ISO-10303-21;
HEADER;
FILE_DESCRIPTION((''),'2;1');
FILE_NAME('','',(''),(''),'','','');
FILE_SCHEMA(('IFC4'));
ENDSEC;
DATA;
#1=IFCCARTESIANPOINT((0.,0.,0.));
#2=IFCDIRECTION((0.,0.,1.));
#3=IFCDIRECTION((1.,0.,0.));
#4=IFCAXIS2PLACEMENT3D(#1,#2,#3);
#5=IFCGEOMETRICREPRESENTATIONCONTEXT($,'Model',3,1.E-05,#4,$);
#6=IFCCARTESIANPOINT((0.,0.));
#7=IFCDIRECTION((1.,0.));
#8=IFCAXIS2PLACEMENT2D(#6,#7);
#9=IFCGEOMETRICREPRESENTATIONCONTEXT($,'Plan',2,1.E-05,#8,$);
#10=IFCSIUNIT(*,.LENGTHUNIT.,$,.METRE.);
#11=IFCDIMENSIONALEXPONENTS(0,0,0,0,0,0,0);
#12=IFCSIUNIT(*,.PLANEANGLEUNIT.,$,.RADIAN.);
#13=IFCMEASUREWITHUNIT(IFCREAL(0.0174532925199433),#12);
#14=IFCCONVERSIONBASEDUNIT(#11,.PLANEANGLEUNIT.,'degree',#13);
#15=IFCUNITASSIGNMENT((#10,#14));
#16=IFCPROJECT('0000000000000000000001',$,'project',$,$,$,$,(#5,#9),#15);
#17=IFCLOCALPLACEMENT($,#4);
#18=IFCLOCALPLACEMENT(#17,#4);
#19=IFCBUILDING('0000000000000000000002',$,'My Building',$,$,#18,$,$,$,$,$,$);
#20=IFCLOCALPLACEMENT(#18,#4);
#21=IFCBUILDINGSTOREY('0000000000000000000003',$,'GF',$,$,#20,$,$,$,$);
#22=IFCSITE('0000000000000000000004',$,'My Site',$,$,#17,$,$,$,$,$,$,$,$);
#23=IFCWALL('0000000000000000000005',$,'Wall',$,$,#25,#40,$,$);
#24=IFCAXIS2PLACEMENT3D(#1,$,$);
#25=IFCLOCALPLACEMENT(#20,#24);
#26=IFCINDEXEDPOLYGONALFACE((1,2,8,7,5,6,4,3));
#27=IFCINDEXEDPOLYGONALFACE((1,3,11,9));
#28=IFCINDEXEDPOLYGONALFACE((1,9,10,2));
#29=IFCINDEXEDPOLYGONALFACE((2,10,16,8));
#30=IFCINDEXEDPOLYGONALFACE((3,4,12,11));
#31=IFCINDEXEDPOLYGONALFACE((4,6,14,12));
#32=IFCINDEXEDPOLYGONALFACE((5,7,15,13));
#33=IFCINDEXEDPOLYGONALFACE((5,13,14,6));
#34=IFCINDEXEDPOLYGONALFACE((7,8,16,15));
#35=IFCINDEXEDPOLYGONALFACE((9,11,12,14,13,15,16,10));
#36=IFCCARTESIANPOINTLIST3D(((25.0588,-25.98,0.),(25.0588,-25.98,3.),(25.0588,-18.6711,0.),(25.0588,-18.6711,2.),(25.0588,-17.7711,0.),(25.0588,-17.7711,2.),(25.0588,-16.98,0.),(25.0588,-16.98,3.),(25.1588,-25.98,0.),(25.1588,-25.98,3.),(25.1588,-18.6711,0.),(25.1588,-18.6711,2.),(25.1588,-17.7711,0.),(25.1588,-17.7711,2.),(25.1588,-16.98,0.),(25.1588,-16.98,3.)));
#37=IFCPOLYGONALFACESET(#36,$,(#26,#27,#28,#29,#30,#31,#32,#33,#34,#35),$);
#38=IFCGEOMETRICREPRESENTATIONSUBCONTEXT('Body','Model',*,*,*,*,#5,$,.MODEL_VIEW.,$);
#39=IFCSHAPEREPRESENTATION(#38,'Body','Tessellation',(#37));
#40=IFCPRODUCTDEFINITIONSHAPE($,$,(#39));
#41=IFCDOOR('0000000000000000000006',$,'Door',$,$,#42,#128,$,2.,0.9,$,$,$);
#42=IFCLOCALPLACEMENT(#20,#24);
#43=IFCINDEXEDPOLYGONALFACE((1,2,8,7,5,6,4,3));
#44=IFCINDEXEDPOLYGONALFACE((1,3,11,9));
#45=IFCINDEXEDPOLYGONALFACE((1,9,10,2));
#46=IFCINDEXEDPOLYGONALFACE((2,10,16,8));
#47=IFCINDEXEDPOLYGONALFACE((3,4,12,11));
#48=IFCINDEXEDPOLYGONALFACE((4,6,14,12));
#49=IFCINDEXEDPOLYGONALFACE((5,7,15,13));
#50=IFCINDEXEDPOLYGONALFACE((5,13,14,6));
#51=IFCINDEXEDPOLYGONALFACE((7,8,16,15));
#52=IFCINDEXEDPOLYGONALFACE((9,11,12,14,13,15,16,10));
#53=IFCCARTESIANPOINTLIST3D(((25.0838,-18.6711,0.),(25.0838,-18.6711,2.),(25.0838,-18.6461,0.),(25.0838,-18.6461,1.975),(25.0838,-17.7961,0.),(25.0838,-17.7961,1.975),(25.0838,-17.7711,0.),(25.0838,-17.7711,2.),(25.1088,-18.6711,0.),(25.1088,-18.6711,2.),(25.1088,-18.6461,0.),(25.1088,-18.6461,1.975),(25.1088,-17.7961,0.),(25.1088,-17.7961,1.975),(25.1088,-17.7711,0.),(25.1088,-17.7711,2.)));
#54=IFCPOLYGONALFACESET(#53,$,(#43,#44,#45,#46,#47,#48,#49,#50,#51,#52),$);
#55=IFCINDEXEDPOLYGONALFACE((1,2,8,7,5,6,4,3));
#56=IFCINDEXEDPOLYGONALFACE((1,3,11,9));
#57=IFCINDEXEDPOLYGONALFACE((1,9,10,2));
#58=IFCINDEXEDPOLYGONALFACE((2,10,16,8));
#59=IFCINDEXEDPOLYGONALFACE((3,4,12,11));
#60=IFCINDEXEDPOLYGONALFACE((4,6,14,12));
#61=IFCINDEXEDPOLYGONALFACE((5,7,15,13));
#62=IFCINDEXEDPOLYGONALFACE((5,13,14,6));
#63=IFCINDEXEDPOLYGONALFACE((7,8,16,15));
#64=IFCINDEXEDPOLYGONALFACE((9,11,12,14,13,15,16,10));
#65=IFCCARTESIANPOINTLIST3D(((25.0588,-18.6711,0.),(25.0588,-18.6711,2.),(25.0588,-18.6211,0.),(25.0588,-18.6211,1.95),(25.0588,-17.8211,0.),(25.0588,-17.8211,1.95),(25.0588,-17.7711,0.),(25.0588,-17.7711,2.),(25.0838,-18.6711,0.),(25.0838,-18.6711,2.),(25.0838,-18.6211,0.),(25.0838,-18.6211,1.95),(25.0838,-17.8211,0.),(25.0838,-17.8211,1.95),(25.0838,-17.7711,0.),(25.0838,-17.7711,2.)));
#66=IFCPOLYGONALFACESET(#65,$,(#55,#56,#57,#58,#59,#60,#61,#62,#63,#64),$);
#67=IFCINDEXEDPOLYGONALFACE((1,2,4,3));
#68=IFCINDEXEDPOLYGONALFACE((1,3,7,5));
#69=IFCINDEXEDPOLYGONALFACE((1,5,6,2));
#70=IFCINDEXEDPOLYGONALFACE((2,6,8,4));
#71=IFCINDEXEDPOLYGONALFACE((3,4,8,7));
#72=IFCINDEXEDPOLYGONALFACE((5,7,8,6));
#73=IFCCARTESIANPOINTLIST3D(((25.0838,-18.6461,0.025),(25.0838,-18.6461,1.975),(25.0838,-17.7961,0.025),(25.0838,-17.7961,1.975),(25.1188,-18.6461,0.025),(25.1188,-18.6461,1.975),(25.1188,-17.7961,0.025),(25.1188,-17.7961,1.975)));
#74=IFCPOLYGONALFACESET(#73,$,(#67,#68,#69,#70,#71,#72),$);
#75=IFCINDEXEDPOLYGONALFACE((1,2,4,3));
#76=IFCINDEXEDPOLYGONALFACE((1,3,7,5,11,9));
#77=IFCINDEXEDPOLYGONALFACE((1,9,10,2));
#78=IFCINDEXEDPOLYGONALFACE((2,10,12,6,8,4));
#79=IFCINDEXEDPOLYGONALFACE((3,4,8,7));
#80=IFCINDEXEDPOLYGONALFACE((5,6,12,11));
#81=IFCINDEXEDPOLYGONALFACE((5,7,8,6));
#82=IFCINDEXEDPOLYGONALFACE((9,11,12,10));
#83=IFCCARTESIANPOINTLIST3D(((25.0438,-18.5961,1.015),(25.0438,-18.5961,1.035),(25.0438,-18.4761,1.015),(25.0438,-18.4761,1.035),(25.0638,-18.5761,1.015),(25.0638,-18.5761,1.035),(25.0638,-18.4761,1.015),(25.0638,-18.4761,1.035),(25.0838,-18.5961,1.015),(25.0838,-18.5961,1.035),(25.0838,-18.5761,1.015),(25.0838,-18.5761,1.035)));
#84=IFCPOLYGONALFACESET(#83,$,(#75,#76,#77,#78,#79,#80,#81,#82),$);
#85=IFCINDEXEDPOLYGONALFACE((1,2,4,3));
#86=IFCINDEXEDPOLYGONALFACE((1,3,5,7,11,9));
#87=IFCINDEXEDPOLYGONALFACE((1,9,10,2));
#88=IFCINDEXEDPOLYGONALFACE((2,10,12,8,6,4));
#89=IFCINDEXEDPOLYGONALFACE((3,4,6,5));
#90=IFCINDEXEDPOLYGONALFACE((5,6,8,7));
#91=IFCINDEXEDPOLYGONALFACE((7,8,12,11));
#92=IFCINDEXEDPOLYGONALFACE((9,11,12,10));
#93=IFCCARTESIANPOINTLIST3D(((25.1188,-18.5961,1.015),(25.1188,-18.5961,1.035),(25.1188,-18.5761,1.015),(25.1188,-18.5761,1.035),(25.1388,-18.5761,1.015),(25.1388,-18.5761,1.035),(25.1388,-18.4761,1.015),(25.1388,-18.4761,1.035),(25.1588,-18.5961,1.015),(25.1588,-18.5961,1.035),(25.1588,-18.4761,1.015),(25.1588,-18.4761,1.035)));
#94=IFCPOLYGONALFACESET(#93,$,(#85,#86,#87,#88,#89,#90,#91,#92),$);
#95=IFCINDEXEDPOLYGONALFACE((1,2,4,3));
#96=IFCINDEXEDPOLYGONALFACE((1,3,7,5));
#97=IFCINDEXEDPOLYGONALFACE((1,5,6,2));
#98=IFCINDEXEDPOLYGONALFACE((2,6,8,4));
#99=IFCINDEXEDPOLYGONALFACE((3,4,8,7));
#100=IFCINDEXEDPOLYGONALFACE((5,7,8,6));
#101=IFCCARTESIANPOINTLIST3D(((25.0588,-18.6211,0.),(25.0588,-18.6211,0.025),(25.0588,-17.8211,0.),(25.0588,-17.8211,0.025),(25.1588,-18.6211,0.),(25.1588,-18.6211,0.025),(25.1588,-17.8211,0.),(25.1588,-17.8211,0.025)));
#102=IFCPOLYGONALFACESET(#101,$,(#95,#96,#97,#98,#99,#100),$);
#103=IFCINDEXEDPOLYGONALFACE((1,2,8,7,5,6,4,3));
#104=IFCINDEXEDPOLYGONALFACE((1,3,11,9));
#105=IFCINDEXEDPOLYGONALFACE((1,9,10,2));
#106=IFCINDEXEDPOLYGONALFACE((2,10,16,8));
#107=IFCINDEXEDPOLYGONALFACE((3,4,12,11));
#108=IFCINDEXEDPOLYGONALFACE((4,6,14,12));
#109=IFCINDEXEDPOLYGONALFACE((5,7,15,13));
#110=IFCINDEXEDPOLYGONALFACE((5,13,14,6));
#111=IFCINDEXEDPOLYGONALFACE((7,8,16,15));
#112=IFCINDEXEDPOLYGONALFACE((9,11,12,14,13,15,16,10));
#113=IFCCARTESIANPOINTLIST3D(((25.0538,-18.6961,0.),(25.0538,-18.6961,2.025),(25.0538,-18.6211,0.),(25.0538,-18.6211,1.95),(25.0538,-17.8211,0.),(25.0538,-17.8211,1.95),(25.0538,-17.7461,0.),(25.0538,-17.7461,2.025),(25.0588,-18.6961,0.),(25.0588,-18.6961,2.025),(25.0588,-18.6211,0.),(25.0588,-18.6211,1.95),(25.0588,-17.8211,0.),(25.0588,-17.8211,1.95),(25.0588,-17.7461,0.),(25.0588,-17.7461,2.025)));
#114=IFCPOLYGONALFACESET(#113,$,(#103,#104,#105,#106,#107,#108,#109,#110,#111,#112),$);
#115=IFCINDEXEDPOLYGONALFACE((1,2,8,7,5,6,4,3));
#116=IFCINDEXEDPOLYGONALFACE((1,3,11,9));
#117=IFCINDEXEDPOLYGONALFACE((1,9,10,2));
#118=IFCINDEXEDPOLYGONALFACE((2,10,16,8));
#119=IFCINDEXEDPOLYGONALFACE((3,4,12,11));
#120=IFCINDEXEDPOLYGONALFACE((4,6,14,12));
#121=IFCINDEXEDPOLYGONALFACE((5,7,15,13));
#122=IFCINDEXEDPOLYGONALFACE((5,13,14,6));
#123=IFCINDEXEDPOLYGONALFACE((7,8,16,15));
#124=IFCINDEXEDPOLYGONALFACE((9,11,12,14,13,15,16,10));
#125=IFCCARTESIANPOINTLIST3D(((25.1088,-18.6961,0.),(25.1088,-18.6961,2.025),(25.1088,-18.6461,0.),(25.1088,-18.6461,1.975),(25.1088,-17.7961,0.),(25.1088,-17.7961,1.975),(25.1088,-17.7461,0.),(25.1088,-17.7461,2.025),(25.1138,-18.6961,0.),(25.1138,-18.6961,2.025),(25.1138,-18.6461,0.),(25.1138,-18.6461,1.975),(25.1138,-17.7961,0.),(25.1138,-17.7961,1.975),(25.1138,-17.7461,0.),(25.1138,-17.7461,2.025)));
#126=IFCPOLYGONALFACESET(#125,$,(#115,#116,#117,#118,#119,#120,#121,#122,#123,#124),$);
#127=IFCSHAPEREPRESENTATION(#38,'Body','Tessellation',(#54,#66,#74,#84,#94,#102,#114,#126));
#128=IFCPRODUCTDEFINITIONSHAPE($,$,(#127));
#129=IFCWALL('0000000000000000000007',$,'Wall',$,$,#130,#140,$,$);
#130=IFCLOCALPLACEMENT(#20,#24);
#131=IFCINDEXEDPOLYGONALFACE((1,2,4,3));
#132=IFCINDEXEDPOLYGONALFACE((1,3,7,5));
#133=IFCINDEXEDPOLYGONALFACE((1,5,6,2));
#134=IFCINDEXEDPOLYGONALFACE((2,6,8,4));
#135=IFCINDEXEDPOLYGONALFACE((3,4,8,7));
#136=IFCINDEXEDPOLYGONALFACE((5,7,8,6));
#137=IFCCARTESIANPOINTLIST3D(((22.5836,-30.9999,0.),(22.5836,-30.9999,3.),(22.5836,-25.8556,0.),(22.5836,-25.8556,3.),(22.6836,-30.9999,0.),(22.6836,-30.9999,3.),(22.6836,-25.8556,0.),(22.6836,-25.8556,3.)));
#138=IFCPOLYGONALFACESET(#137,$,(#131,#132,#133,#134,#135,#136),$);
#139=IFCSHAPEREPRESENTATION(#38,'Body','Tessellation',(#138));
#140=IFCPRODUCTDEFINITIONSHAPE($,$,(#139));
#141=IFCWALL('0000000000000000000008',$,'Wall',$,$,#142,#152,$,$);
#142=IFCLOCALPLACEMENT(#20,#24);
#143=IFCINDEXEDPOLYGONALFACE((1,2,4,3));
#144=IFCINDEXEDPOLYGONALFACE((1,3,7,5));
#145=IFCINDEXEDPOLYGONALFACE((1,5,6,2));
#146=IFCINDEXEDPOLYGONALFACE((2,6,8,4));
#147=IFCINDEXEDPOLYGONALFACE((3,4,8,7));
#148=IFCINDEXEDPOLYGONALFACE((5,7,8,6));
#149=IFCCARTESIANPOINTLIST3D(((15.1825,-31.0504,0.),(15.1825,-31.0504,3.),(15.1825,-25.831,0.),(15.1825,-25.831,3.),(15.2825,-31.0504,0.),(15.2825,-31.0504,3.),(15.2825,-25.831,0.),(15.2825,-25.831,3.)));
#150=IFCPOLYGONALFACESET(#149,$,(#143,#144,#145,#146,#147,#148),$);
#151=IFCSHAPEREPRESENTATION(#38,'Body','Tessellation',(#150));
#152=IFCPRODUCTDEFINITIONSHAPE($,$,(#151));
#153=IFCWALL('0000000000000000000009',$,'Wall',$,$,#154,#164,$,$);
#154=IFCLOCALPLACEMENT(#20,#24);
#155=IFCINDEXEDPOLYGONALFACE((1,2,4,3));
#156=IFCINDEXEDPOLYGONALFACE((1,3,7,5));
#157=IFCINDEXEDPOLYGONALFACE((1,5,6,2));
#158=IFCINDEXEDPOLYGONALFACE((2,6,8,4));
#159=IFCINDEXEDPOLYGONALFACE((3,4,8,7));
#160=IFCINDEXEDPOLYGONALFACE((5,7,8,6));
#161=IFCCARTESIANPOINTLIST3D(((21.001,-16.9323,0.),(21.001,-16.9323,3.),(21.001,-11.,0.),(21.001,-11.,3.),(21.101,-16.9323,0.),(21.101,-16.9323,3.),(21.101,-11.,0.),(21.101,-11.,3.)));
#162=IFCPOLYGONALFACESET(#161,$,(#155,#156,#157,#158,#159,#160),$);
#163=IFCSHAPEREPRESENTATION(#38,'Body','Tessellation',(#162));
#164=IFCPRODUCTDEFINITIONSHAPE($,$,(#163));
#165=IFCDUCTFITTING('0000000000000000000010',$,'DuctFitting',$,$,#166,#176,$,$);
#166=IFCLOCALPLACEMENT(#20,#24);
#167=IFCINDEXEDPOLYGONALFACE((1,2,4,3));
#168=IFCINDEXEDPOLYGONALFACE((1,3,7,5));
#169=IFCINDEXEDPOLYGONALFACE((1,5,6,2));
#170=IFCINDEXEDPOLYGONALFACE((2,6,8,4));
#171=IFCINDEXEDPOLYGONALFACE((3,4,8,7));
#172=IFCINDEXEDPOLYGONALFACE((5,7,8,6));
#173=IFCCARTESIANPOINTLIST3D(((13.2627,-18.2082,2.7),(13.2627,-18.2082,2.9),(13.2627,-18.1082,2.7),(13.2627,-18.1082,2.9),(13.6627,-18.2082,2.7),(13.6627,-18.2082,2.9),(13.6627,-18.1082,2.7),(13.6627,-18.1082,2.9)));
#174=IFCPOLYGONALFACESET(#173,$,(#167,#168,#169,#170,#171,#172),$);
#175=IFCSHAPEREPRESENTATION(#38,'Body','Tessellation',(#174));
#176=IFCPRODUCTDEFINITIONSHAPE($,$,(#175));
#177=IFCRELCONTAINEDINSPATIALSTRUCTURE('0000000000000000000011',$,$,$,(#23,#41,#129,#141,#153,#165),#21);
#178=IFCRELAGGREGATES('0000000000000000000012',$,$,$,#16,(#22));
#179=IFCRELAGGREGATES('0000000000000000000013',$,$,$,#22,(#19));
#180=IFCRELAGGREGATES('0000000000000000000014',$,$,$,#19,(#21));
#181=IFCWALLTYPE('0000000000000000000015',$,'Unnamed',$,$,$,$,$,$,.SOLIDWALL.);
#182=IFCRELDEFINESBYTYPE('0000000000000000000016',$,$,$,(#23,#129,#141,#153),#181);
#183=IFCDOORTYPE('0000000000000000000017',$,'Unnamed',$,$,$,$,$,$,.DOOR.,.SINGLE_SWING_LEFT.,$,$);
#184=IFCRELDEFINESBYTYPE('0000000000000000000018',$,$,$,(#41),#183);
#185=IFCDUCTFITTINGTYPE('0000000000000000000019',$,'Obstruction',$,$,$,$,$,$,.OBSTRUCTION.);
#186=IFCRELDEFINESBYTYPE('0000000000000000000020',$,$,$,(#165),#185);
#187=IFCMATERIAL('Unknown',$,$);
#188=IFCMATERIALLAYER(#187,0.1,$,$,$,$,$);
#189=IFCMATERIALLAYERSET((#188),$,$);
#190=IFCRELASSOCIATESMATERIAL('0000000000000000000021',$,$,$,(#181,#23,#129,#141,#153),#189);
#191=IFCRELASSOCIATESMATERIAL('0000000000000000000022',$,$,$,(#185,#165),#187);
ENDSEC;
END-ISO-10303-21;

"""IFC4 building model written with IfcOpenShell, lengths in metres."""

from ifc_helpers import new_model, entity, si_unit, converted_unit, frame, origin_with_axes, origin_2d_with_axis, place, context, subcontext, project, spatial, line, indexed_curve, rectangle, outline, extrude, shape, source, transform, mapped, material, layer, layer_set, layer_usage, material_profile, profile_set, profile_usage, type_object, type_shapes, element, fill, save


model = new_model("IFC4")

# Units and contexts
model_context = context("Model", 3, precision=1e-05, world=origin_with_axes())
plan_context = context("Plan", 2, precision=1e-05, world=origin_2d_with_axis())
body_context_1 = subcontext(model_context, "Body", "Model", "MODEL_VIEW")
body_context_2 = subcontext(plan_context, "Body", "Plan", "PLAN_VIEW")
ifc_project = project(units=[si_unit("LENGTHUNIT", "METRE"), converted_unit("PLANEANGLEUNIT", "degree", entity("IfcReal", 0.0174532925199433), si_unit("PLANEANGLEUNIT", "RADIAN"), dimensions=[0, 0, 0, 0, 0, 0, 0])], contexts=[model_context, plan_context])

# Site, building, storey
site_placement = place(None, origin_with_axes())
site = spatial("IfcSite", under=ifc_project, at=site_placement, Name="My Site")
building_placement = place(site_placement, origin_with_axes())
building = spatial("IfcBuilding", under=site, at=building_placement, Name="My Building")
storey_placement = place(building_placement, origin_with_axes())
storey = spatial("IfcBuildingStorey", under=building, at=storey_placement, Name="GF")

# Shared definitions
ifc_material = material(Name="Unknown")
ifc_layer = layer(ifc_material, 0.1)
ifc_layer_set = layer_set([ifc_layer])
wall_type = type_object("IfcWallType", Name="Unnamed", PredefinedType="SOLIDWALL", material=ifc_layer_set)

# Shared definitions
shared_shape_1 = source(origin_with_axes(), body_context_1, "Body", "SweptSolid", [
    extrude(outline(indexed_curve([(0.0, 0.0), (0.9, 0.0), (0.9, 2.0), (0.0, 2.0)], segments=[line(1, 2, 3, 4, 1)])), frame((0.0, -0.6, 0.0), z_axis=(0.0, -1.0, 0.0), x_axis=(1.0, 0.0, 0.0)), (0.0, 0.0, -1.0), 1.2),
])
door_type = type_object("IfcDoorType", Name="Unnamed", OperationType="SINGLE_SWING_LEFT", PredefinedType="DOOR")
shared_shape_2 = source(origin_with_axes(), body_context_1, "Body", "SweptSolid", [
    extrude(outline(indexed_curve([(0.0, 0.0), (0.0, 2.0), (0.9, 2.0), (0.9, 0.0), (0.875, 0.0), (0.875, 1.975), (0.025, 1.975), (0.025, 0.0)], segments=[line(1, 2, 3, 4, 5, 6, 7, 8, 1)])), frame((0.0, 0.025, 0.0), z_axis=(0.0, -1.0, 0.0), x_axis=(1.0, 0.0, 0.0)), (0.0, 0.0, -1.0), 0.025),
    extrude(outline(indexed_curve([(0.0, 0.0), (0.0, 2.0), (0.9, 2.0), (0.9, 0.0), (0.85, 0.0), (0.85, 1.95), (0.05, 1.95), (0.05, 0.0)], segments=[line(1, 2, 3, 4, 5, 6, 7, 8, 1)])), frame((0.0, 0.0, 0.0), z_axis=(0.0, -1.0, 0.0), x_axis=(1.0, 0.0, 0.0)), (0.0, 0.0, -1.0), 0.025),
    extrude(outline(indexed_curve([(0.0, 0.0), (0.85, 0.0), (0.85, 0.035), (0.0, 0.035)], segments=[line(1, 2, 3, 4, 1)])), frame((0.025, 0.025, 0.025), z_axis=(0.0, 0.0, 1.0), x_axis=(1.0, 0.0, 0.0)), (0.0, 0.0, 1.0), 1.95),
    extrude(outline(indexed_curve([(0.0, 0.0), (0.0, -0.04), (-0.12, -0.04), (-0.12, -0.02), (-0.02, -0.02), (-0.02, 0.0)], segments=[line(1, 2, 3, 4, 5, 6, 1)])), frame((0.825, 0.025, 1.015), z_axis=(0.0, 0.0, 1.0), x_axis=(1.0, 0.0, 0.0)), (0.0, 0.0, 1.0), 0.02),
    extrude(outline(indexed_curve([(0.0, 0.0), (0.0, 0.04), (-0.12, 0.04), (-0.12, 0.02), (-0.02, 0.02), (-0.02, 0.0)], segments=[line(1, 2, 3, 4, 5, 6, 1)])), frame((0.825, 0.06, 1.015), z_axis=(0.0, 0.0, 1.0), x_axis=(1.0, 0.0, 0.0)), (0.0, 0.0, 1.0), 0.02),
    extrude(outline(indexed_curve([(0.0, 0.0), (0.8, 0.0), (0.8, 0.1), (0.0, 0.1)], segments=[line(1, 2, 3, 4, 1)])), frame((0.05, 0.0, 0.0), z_axis=(0.0, 0.0, 1.0), x_axis=(1.0, 0.0, 0.0)), (0.0, 0.0, 1.0), 0.025),
    extrude(outline(indexed_curve([(0.0, 0.0), (0.0, 2.025), (0.95, 2.025), (0.95, 0.0), (0.875, 0.0), (0.875, 1.95), (0.075, 1.95), (0.075, 0.0)], segments=[line(1, 2, 3, 4, 5, 6, 7, 8, 1)])), frame((-0.025, -0.005, 0.0), z_axis=(0.0, -1.0, 0.0), x_axis=(1.0, 0.0, 0.0)), (0.0, 0.0, -1.0), 0.005),
    extrude(outline(indexed_curve([(0.0, 0.0), (0.0, 2.025), (0.95, 2.025), (0.95, 0.0), (0.9, 0.0), (0.9, 1.975), (0.05, 1.975), (0.05, 0.0)], segments=[line(1, 2, 3, 4, 5, 6, 7, 8, 1)])), frame((-0.025, 0.05, 0.0), z_axis=(0.0, -1.0, 0.0), x_axis=(1.0, 0.0, 0.0)), (0.0, 0.0, -1.0), 0.005),
])
shared_shape_3 = source(origin_with_axes(), body_context_2, "Body", "Curve2D", [
    entity("IfcIndexedPolyCurve", entity("IfcCartesianPointList2D", [[0.0, 0.0], [0.0, 0.05], [0.025, 0.05], [0.025, 0.025], [0.05, 0.025], [0.05, 0.0]]), [entity("IfcLineIndex", [1, 2, 3, 4, 5, 6, 1])]),
    entity("IfcIndexedPolyCurve", entity("IfcCartesianPointList2D", [[0.9, 0.0], [0.9, 0.05], [0.875, 0.05], [0.875, 0.025], [0.85, 0.025], [0.85, 0.0]]), [entity("IfcLineIndex", [1, 2, 3, 4, 5, 6, 1])]),
    entity("IfcTrimmedCurve", entity("IfcEllipse", entity("IfcAxis2Placement2D", entity("IfcCartesianPoint", [0.06, 0.05]), entity("IfcDirection", [1.0, 0.0])), 0.815, 0.85), [entity("IfcCartesianPoint", [0.875, 0.05])], [entity("IfcCartesianPoint", [0.06, 0.9])], True, "CARTESIAN"),
    entity("IfcIndexedPolyCurve", entity("IfcCartesianPointList2D", [[0.025, 0.05], [0.06, 0.05], [0.06, 0.9], [0.025, 0.9]]), [entity("IfcLineIndex", [1, 2, 3, 4, 1])]),
])
type_shapes(door_type, [shared_shape_2, shared_shape_3])

# Wall, opening, door
ifc_layer_usage_1 = layer_usage(ifc_layer_set, "AXIS2", "POSITIVE", 0.0)
wall_1_placement = place(storey_placement, frame((25.0588, -16.98, 0.0), z_axis=(0.0, 0.0, 1.0), x_axis=(0.0, -1.0, 0.0)))
wall_1 = element("IfcWall", 1, at=wall_1_placement, inside=storey, type_object=wall_type, material=ifc_layer_usage_1, Name="Wall", context=body_context_1, shape_type="SweptSolid", body=[
    extrude(outline(indexed_curve([(0.0, 0.0), (0.0, 0.1), (9.0, 0.1), (9.0, 0.0)], segments=[line(1, 2, 3, 4, 1)])), origin_with_axes(), (0.0, 0.0, 1.0), 3.0),
])
opening_1_placement = place(wall_1_placement, frame((0.7911, 0.0, 0.0), z_axis=(0.0, 0.0, 1.0), x_axis=(1.0, 0.0, 0.0)))
opening_1 = element("IfcOpeningElement", 2, at=opening_1_placement, cuts=wall_1, PredefinedType="OPENING", context=body_context_1, shape_type="MappedRepresentation", body=[
    mapped(shared_shape_1, transform((0.0, 0.0, 0.0), x_axis=(1.0, 0.0, 0.0), y_axis=(0.0, 1.0, 0.0), z_axis=(0.0, 0.0, 1.0), scale=1.0)),
])
door_1_placement = place(opening_1_placement, frame((0.0, 0.0, 0.0), z_axis=(0.0, 0.0, 1.0), x_axis=(1.0, 0.0, 0.0)))
door_1 = element("IfcDoor", 3, at=door_1_placement, inside=storey, type_object=door_type, Name="Door", OverallHeight=2.0, OverallWidth=0.9, shapes=[
    shape(body_context_1, "Body", "MappedRepresentation", [mapped(shared_shape_2, transform((0.0, 0.0, 0.0), x_axis=(1.0, 0.0, 0.0), y_axis=(0.0, 1.0, 0.0), z_axis=(0.0, 0.0, 1.0), scale=1.0))]),
    shape(body_context_2, "Body", "MappedRepresentation", [mapped(shared_shape_3, transform((0.0, 0.0, 0.0), x_axis=(1.0, 0.0, 0.0), y_axis=(0.0, 1.0, 0.0), z_axis=(0.0, 0.0, 1.0), scale=1.0))]),
])
fill(opening_1, door_1)

# Walls
ifc_layer_usage_2 = layer_usage(ifc_layer_set, "AXIS2", "POSITIVE", 0.0)
wall_2_placement = place(storey_placement, frame((22.5836, -25.8556, 0.0), z_axis=(0.0, 0.0, 1.0), x_axis=(0.0, -1.0, 0.0)))
element("IfcWall", 4, at=wall_2_placement, inside=storey, type_object=wall_type, material=ifc_layer_usage_2, Name="Wall", context=body_context_1, shape_type="SweptSolid", body=[
    extrude(outline(indexed_curve([(0.0, 0.0), (0.0, 0.1), (5.1443, 0.1), (5.1443, 0.0)], segments=[line(1, 2, 3, 4, 1)])), origin_with_axes(), (0.0, 0.0, 1.0), 3.0),
])
ifc_layer_usage_3 = layer_usage(ifc_layer_set, "AXIS2", "POSITIVE", 0.0)
wall_3_placement = place(storey_placement, frame((15.1825, -25.831, 0.0), z_axis=(0.0, 0.0, 1.0), x_axis=(0.0, -1.0, 0.0)))
element("IfcWall", 5, at=wall_3_placement, inside=storey, type_object=wall_type, material=ifc_layer_usage_3, Name="Wall", context=body_context_1, shape_type="SweptSolid", body=[
    extrude(outline(indexed_curve([(0.0, 0.0), (0.0, 0.1), (5.2194, 0.1), (5.2194, 0.0)], segments=[line(1, 2, 3, 4, 1)])), origin_with_axes(), (0.0, 0.0, 1.0), 3.0),
])
ifc_layer_usage_4 = layer_usage(ifc_layer_set, "AXIS2", "POSITIVE", 0.0)
wall_4_placement = place(storey_placement, frame((21.101, -16.9323, 0.0), z_axis=(0.0, 0.0, 1.0), x_axis=(0.0, 1.0, 0.0)))
element("IfcWall", 6, at=wall_4_placement, inside=storey, type_object=wall_type, material=ifc_layer_usage_4, Name="Wall", context=body_context_1, shape_type="SweptSolid", body=[
    extrude(outline(indexed_curve([(0.0, 0.0), (0.0, 0.1), (5.9323, 0.1), (5.9323, 0.0)], segments=[line(1, 2, 3, 4, 1)])), origin_with_axes(), (0.0, 0.0, 1.0), 3.0),
])

# Duct fitting
ifc_material_profile = material_profile(ifc_material, rectangle(XDim=0.4, YDim=0.2))
ifc_profile_set = profile_set([ifc_material_profile])
ifc_profile_usage_1 = profile_usage(ifc_profile_set, cardinal=5)
duct_fitting_type = type_object("IfcDuctFittingType", Name="Obstruction", PredefinedType="OBSTRUCTION", material=ifc_profile_set)
duct_fitting_1_placement = place(storey_placement, frame((13.4627, -18.2082, 2.8), z_axis=(0.0, 1.0, 0.0), x_axis=(-1.0, 0.0, 0.0)))
element("IfcDuctFitting", 7, at=duct_fitting_1_placement, inside=storey, type_object=duct_fitting_type, material=ifc_profile_usage_1, Name="DuctFitting", context=body_context_1, shape_type="SweptSolid", body=[
    extrude(rectangle(XDim=0.4, YDim=0.2), origin_with_axes(), (0.0, 0.0, 1.0), 0.1),
])

save(model, "model.ifc")
